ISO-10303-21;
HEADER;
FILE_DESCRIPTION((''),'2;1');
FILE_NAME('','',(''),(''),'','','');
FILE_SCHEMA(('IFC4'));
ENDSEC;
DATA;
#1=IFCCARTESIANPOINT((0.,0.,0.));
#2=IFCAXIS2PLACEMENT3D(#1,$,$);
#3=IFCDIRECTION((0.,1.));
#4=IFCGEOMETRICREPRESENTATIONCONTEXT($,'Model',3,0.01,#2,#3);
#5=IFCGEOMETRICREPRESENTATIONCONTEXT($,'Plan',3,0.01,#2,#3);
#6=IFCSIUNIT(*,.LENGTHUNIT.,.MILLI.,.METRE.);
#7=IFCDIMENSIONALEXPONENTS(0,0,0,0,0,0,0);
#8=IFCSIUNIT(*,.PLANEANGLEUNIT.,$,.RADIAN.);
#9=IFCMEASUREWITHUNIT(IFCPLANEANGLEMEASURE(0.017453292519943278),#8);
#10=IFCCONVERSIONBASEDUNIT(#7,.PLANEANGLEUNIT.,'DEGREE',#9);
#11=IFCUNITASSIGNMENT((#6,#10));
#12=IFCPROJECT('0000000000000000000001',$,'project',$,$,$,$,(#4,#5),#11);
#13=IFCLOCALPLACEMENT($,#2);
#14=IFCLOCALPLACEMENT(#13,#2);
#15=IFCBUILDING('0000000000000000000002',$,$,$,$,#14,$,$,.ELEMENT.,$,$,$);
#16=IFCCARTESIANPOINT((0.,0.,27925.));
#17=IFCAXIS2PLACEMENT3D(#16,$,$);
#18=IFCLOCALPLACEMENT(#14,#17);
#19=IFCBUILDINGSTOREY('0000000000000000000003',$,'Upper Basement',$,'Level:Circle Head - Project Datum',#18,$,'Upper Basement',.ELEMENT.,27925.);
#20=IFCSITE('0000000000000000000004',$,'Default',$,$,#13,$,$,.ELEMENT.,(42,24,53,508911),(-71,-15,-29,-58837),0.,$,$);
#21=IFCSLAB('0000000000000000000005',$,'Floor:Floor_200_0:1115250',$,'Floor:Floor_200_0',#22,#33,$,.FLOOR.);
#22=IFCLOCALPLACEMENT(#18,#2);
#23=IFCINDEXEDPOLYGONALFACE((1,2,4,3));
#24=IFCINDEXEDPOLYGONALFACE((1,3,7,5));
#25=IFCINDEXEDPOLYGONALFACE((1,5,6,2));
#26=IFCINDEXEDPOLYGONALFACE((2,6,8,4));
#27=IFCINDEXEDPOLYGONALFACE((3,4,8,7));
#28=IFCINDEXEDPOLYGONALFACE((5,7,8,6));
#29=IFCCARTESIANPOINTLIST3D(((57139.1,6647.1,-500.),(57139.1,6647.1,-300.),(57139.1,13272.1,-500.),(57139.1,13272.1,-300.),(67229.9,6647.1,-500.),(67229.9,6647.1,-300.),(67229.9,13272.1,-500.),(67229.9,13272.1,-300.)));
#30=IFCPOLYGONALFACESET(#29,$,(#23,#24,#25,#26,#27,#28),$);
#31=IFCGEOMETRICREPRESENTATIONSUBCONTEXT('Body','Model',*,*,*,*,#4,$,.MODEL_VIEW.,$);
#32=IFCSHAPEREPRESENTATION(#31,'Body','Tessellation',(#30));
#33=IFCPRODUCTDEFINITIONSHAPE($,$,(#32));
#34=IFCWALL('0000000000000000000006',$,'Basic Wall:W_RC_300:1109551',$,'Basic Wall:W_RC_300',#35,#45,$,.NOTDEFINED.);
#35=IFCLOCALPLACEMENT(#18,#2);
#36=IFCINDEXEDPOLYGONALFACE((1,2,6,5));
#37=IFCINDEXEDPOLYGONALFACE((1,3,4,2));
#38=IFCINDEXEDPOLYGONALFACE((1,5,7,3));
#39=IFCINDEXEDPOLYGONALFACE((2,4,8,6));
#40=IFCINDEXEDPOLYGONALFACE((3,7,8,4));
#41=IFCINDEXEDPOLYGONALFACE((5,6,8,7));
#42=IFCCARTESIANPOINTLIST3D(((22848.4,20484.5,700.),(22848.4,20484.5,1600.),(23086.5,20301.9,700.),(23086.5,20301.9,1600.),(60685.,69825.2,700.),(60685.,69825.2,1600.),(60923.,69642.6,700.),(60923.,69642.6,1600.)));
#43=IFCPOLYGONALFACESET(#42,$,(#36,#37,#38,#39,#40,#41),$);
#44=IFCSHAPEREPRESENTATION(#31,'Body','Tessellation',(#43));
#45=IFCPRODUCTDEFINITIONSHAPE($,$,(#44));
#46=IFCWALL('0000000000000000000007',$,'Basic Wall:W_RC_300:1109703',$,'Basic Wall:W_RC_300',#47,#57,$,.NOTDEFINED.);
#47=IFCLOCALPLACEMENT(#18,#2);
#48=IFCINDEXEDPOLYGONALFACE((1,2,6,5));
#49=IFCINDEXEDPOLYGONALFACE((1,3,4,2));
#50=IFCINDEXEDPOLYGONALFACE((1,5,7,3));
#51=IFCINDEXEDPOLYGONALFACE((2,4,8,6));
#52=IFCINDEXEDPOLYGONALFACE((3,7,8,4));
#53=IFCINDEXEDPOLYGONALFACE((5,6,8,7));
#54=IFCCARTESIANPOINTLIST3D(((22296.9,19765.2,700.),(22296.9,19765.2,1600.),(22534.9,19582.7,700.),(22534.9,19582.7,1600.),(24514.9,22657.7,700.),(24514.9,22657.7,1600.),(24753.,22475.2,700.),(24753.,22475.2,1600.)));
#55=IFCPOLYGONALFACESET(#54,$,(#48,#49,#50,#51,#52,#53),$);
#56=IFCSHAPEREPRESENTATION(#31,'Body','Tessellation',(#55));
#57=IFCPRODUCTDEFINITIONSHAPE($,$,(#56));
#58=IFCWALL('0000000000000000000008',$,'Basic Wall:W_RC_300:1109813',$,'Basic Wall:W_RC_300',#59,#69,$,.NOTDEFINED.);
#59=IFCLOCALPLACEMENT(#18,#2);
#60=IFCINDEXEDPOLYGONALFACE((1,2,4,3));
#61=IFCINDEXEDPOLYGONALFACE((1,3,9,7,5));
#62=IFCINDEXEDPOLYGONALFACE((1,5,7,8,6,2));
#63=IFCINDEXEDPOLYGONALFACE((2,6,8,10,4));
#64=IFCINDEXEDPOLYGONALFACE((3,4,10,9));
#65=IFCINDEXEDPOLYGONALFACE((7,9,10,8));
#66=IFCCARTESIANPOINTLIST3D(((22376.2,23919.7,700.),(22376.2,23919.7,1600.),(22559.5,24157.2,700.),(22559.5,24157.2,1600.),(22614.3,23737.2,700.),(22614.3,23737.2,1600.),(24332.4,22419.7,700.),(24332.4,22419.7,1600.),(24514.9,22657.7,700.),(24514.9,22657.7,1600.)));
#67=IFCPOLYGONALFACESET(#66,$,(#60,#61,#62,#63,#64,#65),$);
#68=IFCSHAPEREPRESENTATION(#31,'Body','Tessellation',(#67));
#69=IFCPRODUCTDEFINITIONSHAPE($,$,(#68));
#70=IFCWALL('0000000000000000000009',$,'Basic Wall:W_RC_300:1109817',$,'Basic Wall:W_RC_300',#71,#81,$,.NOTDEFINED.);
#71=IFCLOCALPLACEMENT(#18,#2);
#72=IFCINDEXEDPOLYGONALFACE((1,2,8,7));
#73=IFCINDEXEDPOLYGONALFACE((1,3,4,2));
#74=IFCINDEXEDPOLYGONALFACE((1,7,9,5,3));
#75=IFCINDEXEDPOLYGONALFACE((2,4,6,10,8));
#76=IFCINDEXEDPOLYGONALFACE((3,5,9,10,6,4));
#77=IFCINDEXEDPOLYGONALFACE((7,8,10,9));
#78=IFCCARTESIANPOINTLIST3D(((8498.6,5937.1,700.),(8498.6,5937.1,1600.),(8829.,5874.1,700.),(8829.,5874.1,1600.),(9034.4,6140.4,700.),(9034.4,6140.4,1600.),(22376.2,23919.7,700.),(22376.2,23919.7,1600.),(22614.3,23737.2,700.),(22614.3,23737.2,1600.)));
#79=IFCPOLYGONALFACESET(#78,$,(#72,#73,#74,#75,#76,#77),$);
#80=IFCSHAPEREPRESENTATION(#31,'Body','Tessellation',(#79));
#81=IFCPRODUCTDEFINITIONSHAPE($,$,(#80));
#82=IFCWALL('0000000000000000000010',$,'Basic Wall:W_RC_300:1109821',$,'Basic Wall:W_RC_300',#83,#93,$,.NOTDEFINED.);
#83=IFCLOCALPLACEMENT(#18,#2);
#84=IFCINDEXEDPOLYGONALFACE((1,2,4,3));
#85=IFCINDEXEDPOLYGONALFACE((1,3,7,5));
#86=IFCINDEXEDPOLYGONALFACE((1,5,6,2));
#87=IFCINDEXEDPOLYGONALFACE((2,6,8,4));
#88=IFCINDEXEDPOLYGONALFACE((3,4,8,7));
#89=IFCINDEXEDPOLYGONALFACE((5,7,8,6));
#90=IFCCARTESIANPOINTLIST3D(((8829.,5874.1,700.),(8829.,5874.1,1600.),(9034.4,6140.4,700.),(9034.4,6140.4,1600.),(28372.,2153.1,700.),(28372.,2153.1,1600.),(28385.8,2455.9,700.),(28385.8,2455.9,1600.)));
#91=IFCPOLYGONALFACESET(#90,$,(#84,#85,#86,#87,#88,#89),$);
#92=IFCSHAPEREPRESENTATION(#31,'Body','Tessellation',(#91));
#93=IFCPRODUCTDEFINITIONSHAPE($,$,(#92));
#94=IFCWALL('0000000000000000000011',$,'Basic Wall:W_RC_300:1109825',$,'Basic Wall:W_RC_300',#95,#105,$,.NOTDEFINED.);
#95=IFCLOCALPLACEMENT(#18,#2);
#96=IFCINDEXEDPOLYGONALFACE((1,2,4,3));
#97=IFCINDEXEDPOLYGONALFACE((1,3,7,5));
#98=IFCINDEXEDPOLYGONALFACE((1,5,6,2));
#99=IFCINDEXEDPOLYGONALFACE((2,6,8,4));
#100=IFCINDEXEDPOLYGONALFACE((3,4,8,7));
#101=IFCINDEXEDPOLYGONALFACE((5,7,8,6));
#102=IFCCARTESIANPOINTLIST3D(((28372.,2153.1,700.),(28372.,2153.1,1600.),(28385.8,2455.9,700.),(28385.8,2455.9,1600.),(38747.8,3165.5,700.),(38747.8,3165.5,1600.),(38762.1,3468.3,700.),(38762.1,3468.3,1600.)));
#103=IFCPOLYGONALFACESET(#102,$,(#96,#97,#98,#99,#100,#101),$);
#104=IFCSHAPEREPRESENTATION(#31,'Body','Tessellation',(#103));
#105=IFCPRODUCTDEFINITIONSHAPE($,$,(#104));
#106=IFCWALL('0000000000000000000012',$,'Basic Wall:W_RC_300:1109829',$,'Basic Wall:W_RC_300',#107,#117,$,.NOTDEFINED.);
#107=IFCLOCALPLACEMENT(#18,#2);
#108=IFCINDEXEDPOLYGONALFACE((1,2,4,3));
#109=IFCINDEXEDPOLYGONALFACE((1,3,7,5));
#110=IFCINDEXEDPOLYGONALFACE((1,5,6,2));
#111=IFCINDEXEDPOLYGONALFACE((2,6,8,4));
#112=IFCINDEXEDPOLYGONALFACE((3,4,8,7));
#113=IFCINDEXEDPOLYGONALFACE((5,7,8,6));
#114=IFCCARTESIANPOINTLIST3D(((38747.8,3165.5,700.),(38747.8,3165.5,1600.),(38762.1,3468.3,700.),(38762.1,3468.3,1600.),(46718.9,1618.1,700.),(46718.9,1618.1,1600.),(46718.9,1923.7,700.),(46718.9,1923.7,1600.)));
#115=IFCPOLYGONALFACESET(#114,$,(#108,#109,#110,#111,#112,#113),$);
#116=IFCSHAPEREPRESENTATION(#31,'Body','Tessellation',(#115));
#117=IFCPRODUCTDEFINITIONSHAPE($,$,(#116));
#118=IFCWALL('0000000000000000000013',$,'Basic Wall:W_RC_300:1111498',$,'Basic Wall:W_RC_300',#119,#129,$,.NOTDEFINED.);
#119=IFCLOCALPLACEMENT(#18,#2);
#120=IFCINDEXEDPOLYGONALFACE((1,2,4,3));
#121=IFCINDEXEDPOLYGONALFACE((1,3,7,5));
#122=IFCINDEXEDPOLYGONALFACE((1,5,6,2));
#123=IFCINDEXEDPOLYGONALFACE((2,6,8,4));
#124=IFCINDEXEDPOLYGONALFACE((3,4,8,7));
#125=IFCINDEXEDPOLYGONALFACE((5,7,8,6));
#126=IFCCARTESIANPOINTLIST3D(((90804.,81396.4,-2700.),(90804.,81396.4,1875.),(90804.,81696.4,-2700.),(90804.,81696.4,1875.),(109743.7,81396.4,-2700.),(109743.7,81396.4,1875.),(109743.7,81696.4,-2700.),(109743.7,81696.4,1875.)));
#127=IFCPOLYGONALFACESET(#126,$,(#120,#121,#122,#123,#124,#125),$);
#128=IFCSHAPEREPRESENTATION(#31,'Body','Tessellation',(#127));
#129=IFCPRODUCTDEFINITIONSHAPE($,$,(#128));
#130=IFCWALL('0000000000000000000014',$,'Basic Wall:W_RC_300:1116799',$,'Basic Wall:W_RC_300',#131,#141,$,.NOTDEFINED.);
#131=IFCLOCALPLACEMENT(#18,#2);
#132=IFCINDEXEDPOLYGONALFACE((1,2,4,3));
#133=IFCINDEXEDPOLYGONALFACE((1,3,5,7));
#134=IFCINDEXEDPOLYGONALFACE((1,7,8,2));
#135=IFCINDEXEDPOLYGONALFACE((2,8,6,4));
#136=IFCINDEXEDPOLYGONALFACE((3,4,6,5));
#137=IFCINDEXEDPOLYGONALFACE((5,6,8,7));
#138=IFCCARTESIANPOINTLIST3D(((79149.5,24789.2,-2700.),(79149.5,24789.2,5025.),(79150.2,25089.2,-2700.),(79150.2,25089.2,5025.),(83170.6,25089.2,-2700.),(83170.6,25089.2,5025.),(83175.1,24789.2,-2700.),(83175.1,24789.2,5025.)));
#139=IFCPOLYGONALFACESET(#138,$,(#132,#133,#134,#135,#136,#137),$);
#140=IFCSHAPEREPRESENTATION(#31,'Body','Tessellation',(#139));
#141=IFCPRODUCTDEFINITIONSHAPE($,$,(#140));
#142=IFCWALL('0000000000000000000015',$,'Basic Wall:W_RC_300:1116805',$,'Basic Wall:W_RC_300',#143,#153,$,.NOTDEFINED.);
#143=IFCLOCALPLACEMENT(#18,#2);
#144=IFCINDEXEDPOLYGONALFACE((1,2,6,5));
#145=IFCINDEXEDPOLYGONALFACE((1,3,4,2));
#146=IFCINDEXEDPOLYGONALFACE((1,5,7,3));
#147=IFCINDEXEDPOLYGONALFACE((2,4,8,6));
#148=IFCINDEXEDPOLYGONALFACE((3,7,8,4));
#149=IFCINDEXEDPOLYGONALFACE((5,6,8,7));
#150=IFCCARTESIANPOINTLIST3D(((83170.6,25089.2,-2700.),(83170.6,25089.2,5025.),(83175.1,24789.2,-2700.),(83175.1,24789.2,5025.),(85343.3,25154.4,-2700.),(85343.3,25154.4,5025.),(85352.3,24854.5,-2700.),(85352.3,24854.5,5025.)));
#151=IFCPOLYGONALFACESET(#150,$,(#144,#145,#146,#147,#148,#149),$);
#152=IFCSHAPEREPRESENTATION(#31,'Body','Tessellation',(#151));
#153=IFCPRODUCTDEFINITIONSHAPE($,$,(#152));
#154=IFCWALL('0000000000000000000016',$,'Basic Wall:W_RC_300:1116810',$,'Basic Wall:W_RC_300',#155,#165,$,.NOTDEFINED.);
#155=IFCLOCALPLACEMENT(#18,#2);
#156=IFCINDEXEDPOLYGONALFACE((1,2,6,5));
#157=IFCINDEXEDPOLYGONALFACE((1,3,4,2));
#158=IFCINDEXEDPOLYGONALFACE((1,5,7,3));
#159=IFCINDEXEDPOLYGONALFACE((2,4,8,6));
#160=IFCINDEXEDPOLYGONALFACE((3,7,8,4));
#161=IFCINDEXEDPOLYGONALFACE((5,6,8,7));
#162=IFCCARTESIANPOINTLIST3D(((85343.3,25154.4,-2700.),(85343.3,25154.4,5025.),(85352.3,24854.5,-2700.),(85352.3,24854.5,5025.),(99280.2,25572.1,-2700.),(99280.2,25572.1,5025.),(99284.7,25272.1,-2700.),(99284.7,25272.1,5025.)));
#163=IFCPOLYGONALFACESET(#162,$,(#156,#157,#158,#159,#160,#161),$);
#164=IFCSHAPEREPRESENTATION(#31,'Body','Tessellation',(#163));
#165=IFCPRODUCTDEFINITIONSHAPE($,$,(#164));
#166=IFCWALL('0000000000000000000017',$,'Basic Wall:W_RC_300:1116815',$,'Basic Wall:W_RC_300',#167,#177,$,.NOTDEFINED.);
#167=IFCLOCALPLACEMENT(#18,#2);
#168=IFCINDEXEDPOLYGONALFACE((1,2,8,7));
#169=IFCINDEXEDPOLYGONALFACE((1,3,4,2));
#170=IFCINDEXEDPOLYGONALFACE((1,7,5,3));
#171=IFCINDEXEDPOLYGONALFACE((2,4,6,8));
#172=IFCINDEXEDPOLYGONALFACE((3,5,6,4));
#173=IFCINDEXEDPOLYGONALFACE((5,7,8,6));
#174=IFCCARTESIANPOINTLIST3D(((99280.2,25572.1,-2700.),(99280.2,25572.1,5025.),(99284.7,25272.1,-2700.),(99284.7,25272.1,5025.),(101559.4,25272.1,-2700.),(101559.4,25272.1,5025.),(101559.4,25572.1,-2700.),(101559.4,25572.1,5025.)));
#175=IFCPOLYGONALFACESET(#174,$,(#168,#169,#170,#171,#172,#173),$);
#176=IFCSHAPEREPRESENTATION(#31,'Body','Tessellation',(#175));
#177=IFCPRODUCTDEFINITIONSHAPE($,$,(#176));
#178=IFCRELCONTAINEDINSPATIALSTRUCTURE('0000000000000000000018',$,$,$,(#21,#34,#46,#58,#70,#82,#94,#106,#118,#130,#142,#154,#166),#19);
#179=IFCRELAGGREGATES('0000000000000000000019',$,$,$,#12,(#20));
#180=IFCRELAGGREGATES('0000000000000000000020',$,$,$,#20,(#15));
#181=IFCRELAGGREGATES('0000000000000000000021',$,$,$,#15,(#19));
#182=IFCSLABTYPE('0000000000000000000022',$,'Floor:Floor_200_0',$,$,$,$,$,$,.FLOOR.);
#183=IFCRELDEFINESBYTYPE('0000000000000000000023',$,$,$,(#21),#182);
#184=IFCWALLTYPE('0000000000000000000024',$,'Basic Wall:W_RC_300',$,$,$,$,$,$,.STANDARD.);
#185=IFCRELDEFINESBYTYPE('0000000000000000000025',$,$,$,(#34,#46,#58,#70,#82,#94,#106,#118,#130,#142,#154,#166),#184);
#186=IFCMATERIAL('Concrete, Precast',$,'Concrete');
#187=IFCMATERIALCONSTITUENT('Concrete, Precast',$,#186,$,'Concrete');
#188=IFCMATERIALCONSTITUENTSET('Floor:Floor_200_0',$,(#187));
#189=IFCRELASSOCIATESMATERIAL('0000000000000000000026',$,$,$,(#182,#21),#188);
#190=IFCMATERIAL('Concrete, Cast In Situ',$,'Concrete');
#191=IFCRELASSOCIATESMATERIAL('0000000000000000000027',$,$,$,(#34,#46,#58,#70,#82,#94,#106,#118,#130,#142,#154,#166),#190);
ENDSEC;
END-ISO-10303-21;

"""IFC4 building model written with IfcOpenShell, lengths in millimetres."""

from ifc_helpers import new_model, entity, si_unit, converted_unit, direction, frame, origin, place, context, subcontext, project, spatial, indexed_curve, outline, extrude, material, constituent, constituent_set, type_object, element, save


model = new_model("IFC4")

# Units and contexts
model_context = context("Model", 3, precision=0.01, world=origin(), true_north=direction((0.0, 1.0)))
plan_context = context("Plan", 3, precision=0.01, world=origin(), true_north=direction((0.0, 1.0)))
body_context = subcontext(model_context, "Body", "Model", "MODEL_VIEW")
ifc_project = project(units=[si_unit("LENGTHUNIT", "METRE", prefix="MILLI"), converted_unit("PLANEANGLEUNIT", "DEGREE", entity("IfcPlaneAngleMeasure", 0.017453292519943278), si_unit("PLANEANGLEUNIT", "RADIAN"), dimensions=[0, 0, 0, 0, 0, 0, 0])], contexts=[model_context, plan_context])

# Site, building, storey
site_placement = place(None, origin())
site = spatial("IfcSite", under=ifc_project, at=site_placement, Name="Default", CompositionType="ELEMENT", RefLatitude=(42, 24, 53, 508911), RefLongitude=(-71, -15, -29, -58837), RefElevation=0.0)
building_placement = place(site_placement, origin())
building = spatial("IfcBuilding", under=site, at=building_placement, CompositionType="ELEMENT")
storey_placement = place(building_placement, frame((0.0, 0.0, 27925.0)))
storey = spatial("IfcBuildingStorey", under=building, at=storey_placement, Name="Upper Basement", ObjectType="Level:Circle Head - Project Datum", LongName="Upper Basement", CompositionType="ELEMENT", Elevation=27925.0)

# Slab
ifc_material_1 = material(Name="Concrete, Precast", Category="Concrete")
ifc_constituent = constituent(ifc_material_1, Name="Concrete, Precast", Category="Concrete")
ifc_constituent_set = constituent_set(constituents=[ifc_constituent], Name="Floor:Floor_200_0")
slab_type = type_object("IfcSlabType", Name="Floor:Floor_200_0", PredefinedType="FLOOR", material=ifc_constituent_set)
slab_1_placement = place(storey_placement, origin())
element("IfcSlab", 1, at=slab_1_placement, inside=storey, type_object=slab_type, material=ifc_constituent_set, Name="Floor:Floor_200_0:1115250", ObjectType="Floor:Floor_200_0", PredefinedType="FLOOR", context=body_context, shape_type="SweptSolid", body=[
    extrude(outline(indexed_curve([(-3312.5, -5045.4), (3312.5, -5045.4), (3312.5, 5045.4), (-3312.5, 5045.4), (-3312.5, -5045.4)], self_intersect=False)), frame((62184.5, 9959.6, -300.0), z_axis=(0.0, 0.0, -1.0), x_axis=(0.0, 1.0, 0.0)), (0.0, 0.0, 1.0), 200.0),
])

# Walls
ifc_material_2 = material(Name="Concrete, Cast In Situ", Category="Concrete")
wall_type = type_object("IfcWallType", Name="Basic Wall:W_RC_300", PredefinedType="STANDARD")
wall_1_placement = place(storey_placement, frame((60804.0, 69733.9, 700.0), z_axis=(0.0, 0.0, 1.0), x_axis=(-0.60852, -0.793539, 0.0)))
element("IfcWall", 2, at=wall_1_placement, inside=storey, type_object=wall_type, material=ifc_material_2, Name="Basic Wall:W_RC_300:1109551", ObjectType="Basic Wall:W_RC_300", PredefinedType="NOTDEFINED", context=body_context, shape_type="SweptSolid", body=[
    extrude(outline(indexed_curve([(62178.0, 150.0), (0.0, 150.0), (0.0, -150.0), (62178.0, -150.0), (62178.0, 150.0)], self_intersect=False)), origin(), (0.0, 0.0, 1.0), 900.0),
])
wall_2_placement = place(storey_placement, frame((22415.9, 19674.0, 700.0), z_axis=(0.0, 0.0, 1.0), x_axis=(0.60852, 0.793539, 0.0)))
element("IfcWall", 3, at=wall_2_placement, inside=storey, type_object=wall_type, material=ifc_material_2, Name="Basic Wall:W_RC_300:1109703", ObjectType="Basic Wall:W_RC_300", PredefinedType="NOTDEFINED", context=body_context, shape_type="SweptSolid", body=[
    extrude(outline(indexed_curve([(3645.0, 150.0), (0.0, 150.0), (0.0, -150.0), (3645.0, -150.0), (3645.0, 150.0)], self_intersect=False)), origin(), (0.0, 0.0, 1.0), 900.0),
])
wall_3_placement = place(storey_placement, frame((22467.5, 24038.8, 700.0), z_axis=(0.0, 0.0, 1.0), x_axis=(0.793539, -0.60852, 0.0)))
element("IfcWall", 4, at=wall_3_placement, inside=storey, type_object=wall_type, material=ifc_material_2, Name="Basic Wall:W_RC_300:1109813", ObjectType="Basic Wall:W_RC_300", PredefinedType="NOTDEFINED", context=body_context, shape_type="SweptSolid", body=[
    extrude(outline(indexed_curve([(2465.1, -150.0), (2465.1, 150.0), (0.9, 150.0), (0.0, -150.0), (300.0, -150.0), (2465.1, -150.0)], self_intersect=False)), origin(), (0.0, 0.0, 1.0), 900.0),
])
wall_4_placement = place(storey_placement, frame((8617.3, 5845.4, 700.0), z_axis=(0.0, 0.0, 1.0), x_axis=(0.61095, 0.79167, 0.0)))
element("IfcWall", 5, at=wall_4_placement, inside=storey, type_object=wall_type, material=ifc_material_2, Name="Basic Wall:W_RC_300:1109817", ObjectType="Basic Wall:W_RC_300", PredefinedType="NOTDEFINED", context=body_context, shape_type="SweptSolid", body=[
    extrude(outline(indexed_curve([(22715.8, -150.0), (22714.9, 150.0), (0.0, 150.0), (152.1, -150.0), (488.4, -150.0), (22715.8, -150.0)], self_intersect=False)), origin(), (0.0, 0.0, 1.0), 900.0),
])
wall_5_placement = place(storey_placement, frame((28400.1, 2300.4, 700.0), z_axis=(0.0, 0.0, 1.0), x_axis=(-0.982352, 0.187043, 0.0)))
element("IfcWall", 6, at=wall_5_placement, inside=storey, type_object=wall_type, material=ifc_material_2, Name="Basic Wall:W_RC_300:1109821", ObjectType="Basic Wall:W_RC_300", PredefinedType="NOTDEFINED", context=body_context, shape_type="SweptSolid", body=[
    extrude(outline(indexed_curve([(19742.1, -150.0), (19894.1, 150.0), (0.0, 150.0), (43.1, -150.0), (19742.1, -150.0)], self_intersect=False)), origin(), (0.0, 0.0, 1.0), 900.0),
])
wall_6_placement = place(storey_placement, frame((38776.7, 3319.0, 700.0), z_axis=(0.0, 0.0, 1.0), x_axis=(-0.995274, -0.09711, 0.0)))
element("IfcWall", 7, at=wall_6_placement, inside=storey, type_object=wall_type, material=ifc_material_2, Name="Basic Wall:W_RC_300:1109825", ObjectType="Basic Wall:W_RC_300", PredefinedType="NOTDEFINED", context=body_context, shape_type="SweptSolid", body=[
    extrude(outline(indexed_curve([(10425.6, -150.0), (10468.7, 150.0), (43.7, 150.0), (0.0, -150.0), (10425.6, -150.0)], self_intersect=False)), origin(), (0.0, 0.0, 1.0), 900.0),
])
wall_7_placement = place(storey_placement, frame((46747.5, 1765.3, 700.0), z_axis=(0.0, 0.0, 1.0), x_axis=(-0.981674, 0.190569, 0.0)))
element("IfcWall", 8, at=wall_7_placement, inside=storey, type_object=wall_type, material=ifc_material_2, Name="Basic Wall:W_RC_300:1109829", ObjectType="Basic Wall:W_RC_300", PredefinedType="NOTDEFINED", context=body_context, shape_type="SweptSolid", body=[
    extrude(outline(indexed_curve([(8163.6, -150.0), (8119.9, 150.0), (0.0, 150.0), (58.2, -150.0), (8163.6, -150.0)], self_intersect=False)), origin(), (0.0, 0.0, 1.0), 900.0),
])
wall_8_placement = place(storey_placement, frame((90804.0, 81546.4, -2700.0)))
element("IfcWall", 9, at=wall_8_placement, inside=storey, type_object=wall_type, material=ifc_material_2, Name="Basic Wall:W_RC_300:1111498", ObjectType="Basic Wall:W_RC_300", PredefinedType="NOTDEFINED", context=body_context, shape_type="SweptSolid", body=[
    extrude(outline(indexed_curve([(18939.7, 150.0), (0.0, 150.0), (0.0, -150.0), (18939.7, -150.0), (18939.7, 150.0)], self_intersect=False)), origin(), (0.0, 0.0, 1.0), 4575.0),
])
wall_9_placement = place(storey_placement, frame((79149.5, 24939.2, -2700.0)))
element("IfcWall", 10, at=wall_9_placement, inside=storey, type_object=wall_type, material=ifc_material_2, Name="Basic Wall:W_RC_300:1116799", ObjectType="Basic Wall:W_RC_300", PredefinedType="NOTDEFINED", context=body_context, shape_type="SweptSolid", body=[
    extrude(outline(indexed_curve([(4025.6, -150.0), (4021.1, 150.0), (0.6, 150.0), (0.0, -150.0), (4025.6, -150.0)], self_intersect=False)), origin(), (0.0, 0.0, 1.0), 7725.0),
])
wall_10_placement = place(storey_placement, frame((83170.6, 24939.2, -2700.0), z_axis=(0.0, 0.0, 1.0), x_axis=(0.999551, 0.029963, 0.0)))
element("IfcWall", 11, at=wall_10_placement, inside=storey, type_object=wall_type, material=ifc_material_2, Name="Basic Wall:W_RC_300:1116805", ObjectType="Basic Wall:W_RC_300", PredefinedType="NOTDEFINED", context=body_context, shape_type="SweptSolid", body=[
    extrude(outline(indexed_curve([(2178.2, -150.0), (2178.2, 150.0), (4.5, 150.0), (0.0, -150.0), (2178.2, -150.0)], self_intersect=False)), origin(), (0.0, 0.0, 1.0), 7725.0),
])
wall_11_placement = place(storey_placement, frame((85347.8, 25004.4, -2700.0), z_axis=(0.0, 0.0, 1.0), x_axis=(0.999551, 0.029963, 0.0)))
element("IfcWall", 12, at=wall_11_placement, inside=storey, type_object=wall_type, material=ifc_material_2, Name="Basic Wall:W_RC_300:1116810", ObjectType="Basic Wall:W_RC_300", PredefinedType="NOTDEFINED", context=body_context, shape_type="SweptSolid", body=[
    extrude(outline(indexed_curve([(13938.6, -150.0), (13943.1, 150.0), (0.0, 150.0), (0.0, -150.0), (13938.6, -150.0)], self_intersect=False)), origin(), (0.0, 0.0, 1.0), 7725.0),
])
wall_12_placement = place(storey_placement, frame((99280.2, 25422.1, -2700.0)))
element("IfcWall", 13, at=wall_12_placement, inside=storey, type_object=wall_type, material=ifc_material_2, Name="Basic Wall:W_RC_300:1116815", ObjectType="Basic Wall:W_RC_300", PredefinedType="NOTDEFINED", context=body_context, shape_type="SweptSolid", body=[
    extrude(outline(indexed_curve([(2279.3, -150.0), (2279.3, 150.0), (0.0, 150.0), (4.5, -150.0), (2279.3, -150.0)], self_intersect=False)), origin(), (0.0, 0.0, 1.0), 7725.0),
])

save(model, "model.ifc")
